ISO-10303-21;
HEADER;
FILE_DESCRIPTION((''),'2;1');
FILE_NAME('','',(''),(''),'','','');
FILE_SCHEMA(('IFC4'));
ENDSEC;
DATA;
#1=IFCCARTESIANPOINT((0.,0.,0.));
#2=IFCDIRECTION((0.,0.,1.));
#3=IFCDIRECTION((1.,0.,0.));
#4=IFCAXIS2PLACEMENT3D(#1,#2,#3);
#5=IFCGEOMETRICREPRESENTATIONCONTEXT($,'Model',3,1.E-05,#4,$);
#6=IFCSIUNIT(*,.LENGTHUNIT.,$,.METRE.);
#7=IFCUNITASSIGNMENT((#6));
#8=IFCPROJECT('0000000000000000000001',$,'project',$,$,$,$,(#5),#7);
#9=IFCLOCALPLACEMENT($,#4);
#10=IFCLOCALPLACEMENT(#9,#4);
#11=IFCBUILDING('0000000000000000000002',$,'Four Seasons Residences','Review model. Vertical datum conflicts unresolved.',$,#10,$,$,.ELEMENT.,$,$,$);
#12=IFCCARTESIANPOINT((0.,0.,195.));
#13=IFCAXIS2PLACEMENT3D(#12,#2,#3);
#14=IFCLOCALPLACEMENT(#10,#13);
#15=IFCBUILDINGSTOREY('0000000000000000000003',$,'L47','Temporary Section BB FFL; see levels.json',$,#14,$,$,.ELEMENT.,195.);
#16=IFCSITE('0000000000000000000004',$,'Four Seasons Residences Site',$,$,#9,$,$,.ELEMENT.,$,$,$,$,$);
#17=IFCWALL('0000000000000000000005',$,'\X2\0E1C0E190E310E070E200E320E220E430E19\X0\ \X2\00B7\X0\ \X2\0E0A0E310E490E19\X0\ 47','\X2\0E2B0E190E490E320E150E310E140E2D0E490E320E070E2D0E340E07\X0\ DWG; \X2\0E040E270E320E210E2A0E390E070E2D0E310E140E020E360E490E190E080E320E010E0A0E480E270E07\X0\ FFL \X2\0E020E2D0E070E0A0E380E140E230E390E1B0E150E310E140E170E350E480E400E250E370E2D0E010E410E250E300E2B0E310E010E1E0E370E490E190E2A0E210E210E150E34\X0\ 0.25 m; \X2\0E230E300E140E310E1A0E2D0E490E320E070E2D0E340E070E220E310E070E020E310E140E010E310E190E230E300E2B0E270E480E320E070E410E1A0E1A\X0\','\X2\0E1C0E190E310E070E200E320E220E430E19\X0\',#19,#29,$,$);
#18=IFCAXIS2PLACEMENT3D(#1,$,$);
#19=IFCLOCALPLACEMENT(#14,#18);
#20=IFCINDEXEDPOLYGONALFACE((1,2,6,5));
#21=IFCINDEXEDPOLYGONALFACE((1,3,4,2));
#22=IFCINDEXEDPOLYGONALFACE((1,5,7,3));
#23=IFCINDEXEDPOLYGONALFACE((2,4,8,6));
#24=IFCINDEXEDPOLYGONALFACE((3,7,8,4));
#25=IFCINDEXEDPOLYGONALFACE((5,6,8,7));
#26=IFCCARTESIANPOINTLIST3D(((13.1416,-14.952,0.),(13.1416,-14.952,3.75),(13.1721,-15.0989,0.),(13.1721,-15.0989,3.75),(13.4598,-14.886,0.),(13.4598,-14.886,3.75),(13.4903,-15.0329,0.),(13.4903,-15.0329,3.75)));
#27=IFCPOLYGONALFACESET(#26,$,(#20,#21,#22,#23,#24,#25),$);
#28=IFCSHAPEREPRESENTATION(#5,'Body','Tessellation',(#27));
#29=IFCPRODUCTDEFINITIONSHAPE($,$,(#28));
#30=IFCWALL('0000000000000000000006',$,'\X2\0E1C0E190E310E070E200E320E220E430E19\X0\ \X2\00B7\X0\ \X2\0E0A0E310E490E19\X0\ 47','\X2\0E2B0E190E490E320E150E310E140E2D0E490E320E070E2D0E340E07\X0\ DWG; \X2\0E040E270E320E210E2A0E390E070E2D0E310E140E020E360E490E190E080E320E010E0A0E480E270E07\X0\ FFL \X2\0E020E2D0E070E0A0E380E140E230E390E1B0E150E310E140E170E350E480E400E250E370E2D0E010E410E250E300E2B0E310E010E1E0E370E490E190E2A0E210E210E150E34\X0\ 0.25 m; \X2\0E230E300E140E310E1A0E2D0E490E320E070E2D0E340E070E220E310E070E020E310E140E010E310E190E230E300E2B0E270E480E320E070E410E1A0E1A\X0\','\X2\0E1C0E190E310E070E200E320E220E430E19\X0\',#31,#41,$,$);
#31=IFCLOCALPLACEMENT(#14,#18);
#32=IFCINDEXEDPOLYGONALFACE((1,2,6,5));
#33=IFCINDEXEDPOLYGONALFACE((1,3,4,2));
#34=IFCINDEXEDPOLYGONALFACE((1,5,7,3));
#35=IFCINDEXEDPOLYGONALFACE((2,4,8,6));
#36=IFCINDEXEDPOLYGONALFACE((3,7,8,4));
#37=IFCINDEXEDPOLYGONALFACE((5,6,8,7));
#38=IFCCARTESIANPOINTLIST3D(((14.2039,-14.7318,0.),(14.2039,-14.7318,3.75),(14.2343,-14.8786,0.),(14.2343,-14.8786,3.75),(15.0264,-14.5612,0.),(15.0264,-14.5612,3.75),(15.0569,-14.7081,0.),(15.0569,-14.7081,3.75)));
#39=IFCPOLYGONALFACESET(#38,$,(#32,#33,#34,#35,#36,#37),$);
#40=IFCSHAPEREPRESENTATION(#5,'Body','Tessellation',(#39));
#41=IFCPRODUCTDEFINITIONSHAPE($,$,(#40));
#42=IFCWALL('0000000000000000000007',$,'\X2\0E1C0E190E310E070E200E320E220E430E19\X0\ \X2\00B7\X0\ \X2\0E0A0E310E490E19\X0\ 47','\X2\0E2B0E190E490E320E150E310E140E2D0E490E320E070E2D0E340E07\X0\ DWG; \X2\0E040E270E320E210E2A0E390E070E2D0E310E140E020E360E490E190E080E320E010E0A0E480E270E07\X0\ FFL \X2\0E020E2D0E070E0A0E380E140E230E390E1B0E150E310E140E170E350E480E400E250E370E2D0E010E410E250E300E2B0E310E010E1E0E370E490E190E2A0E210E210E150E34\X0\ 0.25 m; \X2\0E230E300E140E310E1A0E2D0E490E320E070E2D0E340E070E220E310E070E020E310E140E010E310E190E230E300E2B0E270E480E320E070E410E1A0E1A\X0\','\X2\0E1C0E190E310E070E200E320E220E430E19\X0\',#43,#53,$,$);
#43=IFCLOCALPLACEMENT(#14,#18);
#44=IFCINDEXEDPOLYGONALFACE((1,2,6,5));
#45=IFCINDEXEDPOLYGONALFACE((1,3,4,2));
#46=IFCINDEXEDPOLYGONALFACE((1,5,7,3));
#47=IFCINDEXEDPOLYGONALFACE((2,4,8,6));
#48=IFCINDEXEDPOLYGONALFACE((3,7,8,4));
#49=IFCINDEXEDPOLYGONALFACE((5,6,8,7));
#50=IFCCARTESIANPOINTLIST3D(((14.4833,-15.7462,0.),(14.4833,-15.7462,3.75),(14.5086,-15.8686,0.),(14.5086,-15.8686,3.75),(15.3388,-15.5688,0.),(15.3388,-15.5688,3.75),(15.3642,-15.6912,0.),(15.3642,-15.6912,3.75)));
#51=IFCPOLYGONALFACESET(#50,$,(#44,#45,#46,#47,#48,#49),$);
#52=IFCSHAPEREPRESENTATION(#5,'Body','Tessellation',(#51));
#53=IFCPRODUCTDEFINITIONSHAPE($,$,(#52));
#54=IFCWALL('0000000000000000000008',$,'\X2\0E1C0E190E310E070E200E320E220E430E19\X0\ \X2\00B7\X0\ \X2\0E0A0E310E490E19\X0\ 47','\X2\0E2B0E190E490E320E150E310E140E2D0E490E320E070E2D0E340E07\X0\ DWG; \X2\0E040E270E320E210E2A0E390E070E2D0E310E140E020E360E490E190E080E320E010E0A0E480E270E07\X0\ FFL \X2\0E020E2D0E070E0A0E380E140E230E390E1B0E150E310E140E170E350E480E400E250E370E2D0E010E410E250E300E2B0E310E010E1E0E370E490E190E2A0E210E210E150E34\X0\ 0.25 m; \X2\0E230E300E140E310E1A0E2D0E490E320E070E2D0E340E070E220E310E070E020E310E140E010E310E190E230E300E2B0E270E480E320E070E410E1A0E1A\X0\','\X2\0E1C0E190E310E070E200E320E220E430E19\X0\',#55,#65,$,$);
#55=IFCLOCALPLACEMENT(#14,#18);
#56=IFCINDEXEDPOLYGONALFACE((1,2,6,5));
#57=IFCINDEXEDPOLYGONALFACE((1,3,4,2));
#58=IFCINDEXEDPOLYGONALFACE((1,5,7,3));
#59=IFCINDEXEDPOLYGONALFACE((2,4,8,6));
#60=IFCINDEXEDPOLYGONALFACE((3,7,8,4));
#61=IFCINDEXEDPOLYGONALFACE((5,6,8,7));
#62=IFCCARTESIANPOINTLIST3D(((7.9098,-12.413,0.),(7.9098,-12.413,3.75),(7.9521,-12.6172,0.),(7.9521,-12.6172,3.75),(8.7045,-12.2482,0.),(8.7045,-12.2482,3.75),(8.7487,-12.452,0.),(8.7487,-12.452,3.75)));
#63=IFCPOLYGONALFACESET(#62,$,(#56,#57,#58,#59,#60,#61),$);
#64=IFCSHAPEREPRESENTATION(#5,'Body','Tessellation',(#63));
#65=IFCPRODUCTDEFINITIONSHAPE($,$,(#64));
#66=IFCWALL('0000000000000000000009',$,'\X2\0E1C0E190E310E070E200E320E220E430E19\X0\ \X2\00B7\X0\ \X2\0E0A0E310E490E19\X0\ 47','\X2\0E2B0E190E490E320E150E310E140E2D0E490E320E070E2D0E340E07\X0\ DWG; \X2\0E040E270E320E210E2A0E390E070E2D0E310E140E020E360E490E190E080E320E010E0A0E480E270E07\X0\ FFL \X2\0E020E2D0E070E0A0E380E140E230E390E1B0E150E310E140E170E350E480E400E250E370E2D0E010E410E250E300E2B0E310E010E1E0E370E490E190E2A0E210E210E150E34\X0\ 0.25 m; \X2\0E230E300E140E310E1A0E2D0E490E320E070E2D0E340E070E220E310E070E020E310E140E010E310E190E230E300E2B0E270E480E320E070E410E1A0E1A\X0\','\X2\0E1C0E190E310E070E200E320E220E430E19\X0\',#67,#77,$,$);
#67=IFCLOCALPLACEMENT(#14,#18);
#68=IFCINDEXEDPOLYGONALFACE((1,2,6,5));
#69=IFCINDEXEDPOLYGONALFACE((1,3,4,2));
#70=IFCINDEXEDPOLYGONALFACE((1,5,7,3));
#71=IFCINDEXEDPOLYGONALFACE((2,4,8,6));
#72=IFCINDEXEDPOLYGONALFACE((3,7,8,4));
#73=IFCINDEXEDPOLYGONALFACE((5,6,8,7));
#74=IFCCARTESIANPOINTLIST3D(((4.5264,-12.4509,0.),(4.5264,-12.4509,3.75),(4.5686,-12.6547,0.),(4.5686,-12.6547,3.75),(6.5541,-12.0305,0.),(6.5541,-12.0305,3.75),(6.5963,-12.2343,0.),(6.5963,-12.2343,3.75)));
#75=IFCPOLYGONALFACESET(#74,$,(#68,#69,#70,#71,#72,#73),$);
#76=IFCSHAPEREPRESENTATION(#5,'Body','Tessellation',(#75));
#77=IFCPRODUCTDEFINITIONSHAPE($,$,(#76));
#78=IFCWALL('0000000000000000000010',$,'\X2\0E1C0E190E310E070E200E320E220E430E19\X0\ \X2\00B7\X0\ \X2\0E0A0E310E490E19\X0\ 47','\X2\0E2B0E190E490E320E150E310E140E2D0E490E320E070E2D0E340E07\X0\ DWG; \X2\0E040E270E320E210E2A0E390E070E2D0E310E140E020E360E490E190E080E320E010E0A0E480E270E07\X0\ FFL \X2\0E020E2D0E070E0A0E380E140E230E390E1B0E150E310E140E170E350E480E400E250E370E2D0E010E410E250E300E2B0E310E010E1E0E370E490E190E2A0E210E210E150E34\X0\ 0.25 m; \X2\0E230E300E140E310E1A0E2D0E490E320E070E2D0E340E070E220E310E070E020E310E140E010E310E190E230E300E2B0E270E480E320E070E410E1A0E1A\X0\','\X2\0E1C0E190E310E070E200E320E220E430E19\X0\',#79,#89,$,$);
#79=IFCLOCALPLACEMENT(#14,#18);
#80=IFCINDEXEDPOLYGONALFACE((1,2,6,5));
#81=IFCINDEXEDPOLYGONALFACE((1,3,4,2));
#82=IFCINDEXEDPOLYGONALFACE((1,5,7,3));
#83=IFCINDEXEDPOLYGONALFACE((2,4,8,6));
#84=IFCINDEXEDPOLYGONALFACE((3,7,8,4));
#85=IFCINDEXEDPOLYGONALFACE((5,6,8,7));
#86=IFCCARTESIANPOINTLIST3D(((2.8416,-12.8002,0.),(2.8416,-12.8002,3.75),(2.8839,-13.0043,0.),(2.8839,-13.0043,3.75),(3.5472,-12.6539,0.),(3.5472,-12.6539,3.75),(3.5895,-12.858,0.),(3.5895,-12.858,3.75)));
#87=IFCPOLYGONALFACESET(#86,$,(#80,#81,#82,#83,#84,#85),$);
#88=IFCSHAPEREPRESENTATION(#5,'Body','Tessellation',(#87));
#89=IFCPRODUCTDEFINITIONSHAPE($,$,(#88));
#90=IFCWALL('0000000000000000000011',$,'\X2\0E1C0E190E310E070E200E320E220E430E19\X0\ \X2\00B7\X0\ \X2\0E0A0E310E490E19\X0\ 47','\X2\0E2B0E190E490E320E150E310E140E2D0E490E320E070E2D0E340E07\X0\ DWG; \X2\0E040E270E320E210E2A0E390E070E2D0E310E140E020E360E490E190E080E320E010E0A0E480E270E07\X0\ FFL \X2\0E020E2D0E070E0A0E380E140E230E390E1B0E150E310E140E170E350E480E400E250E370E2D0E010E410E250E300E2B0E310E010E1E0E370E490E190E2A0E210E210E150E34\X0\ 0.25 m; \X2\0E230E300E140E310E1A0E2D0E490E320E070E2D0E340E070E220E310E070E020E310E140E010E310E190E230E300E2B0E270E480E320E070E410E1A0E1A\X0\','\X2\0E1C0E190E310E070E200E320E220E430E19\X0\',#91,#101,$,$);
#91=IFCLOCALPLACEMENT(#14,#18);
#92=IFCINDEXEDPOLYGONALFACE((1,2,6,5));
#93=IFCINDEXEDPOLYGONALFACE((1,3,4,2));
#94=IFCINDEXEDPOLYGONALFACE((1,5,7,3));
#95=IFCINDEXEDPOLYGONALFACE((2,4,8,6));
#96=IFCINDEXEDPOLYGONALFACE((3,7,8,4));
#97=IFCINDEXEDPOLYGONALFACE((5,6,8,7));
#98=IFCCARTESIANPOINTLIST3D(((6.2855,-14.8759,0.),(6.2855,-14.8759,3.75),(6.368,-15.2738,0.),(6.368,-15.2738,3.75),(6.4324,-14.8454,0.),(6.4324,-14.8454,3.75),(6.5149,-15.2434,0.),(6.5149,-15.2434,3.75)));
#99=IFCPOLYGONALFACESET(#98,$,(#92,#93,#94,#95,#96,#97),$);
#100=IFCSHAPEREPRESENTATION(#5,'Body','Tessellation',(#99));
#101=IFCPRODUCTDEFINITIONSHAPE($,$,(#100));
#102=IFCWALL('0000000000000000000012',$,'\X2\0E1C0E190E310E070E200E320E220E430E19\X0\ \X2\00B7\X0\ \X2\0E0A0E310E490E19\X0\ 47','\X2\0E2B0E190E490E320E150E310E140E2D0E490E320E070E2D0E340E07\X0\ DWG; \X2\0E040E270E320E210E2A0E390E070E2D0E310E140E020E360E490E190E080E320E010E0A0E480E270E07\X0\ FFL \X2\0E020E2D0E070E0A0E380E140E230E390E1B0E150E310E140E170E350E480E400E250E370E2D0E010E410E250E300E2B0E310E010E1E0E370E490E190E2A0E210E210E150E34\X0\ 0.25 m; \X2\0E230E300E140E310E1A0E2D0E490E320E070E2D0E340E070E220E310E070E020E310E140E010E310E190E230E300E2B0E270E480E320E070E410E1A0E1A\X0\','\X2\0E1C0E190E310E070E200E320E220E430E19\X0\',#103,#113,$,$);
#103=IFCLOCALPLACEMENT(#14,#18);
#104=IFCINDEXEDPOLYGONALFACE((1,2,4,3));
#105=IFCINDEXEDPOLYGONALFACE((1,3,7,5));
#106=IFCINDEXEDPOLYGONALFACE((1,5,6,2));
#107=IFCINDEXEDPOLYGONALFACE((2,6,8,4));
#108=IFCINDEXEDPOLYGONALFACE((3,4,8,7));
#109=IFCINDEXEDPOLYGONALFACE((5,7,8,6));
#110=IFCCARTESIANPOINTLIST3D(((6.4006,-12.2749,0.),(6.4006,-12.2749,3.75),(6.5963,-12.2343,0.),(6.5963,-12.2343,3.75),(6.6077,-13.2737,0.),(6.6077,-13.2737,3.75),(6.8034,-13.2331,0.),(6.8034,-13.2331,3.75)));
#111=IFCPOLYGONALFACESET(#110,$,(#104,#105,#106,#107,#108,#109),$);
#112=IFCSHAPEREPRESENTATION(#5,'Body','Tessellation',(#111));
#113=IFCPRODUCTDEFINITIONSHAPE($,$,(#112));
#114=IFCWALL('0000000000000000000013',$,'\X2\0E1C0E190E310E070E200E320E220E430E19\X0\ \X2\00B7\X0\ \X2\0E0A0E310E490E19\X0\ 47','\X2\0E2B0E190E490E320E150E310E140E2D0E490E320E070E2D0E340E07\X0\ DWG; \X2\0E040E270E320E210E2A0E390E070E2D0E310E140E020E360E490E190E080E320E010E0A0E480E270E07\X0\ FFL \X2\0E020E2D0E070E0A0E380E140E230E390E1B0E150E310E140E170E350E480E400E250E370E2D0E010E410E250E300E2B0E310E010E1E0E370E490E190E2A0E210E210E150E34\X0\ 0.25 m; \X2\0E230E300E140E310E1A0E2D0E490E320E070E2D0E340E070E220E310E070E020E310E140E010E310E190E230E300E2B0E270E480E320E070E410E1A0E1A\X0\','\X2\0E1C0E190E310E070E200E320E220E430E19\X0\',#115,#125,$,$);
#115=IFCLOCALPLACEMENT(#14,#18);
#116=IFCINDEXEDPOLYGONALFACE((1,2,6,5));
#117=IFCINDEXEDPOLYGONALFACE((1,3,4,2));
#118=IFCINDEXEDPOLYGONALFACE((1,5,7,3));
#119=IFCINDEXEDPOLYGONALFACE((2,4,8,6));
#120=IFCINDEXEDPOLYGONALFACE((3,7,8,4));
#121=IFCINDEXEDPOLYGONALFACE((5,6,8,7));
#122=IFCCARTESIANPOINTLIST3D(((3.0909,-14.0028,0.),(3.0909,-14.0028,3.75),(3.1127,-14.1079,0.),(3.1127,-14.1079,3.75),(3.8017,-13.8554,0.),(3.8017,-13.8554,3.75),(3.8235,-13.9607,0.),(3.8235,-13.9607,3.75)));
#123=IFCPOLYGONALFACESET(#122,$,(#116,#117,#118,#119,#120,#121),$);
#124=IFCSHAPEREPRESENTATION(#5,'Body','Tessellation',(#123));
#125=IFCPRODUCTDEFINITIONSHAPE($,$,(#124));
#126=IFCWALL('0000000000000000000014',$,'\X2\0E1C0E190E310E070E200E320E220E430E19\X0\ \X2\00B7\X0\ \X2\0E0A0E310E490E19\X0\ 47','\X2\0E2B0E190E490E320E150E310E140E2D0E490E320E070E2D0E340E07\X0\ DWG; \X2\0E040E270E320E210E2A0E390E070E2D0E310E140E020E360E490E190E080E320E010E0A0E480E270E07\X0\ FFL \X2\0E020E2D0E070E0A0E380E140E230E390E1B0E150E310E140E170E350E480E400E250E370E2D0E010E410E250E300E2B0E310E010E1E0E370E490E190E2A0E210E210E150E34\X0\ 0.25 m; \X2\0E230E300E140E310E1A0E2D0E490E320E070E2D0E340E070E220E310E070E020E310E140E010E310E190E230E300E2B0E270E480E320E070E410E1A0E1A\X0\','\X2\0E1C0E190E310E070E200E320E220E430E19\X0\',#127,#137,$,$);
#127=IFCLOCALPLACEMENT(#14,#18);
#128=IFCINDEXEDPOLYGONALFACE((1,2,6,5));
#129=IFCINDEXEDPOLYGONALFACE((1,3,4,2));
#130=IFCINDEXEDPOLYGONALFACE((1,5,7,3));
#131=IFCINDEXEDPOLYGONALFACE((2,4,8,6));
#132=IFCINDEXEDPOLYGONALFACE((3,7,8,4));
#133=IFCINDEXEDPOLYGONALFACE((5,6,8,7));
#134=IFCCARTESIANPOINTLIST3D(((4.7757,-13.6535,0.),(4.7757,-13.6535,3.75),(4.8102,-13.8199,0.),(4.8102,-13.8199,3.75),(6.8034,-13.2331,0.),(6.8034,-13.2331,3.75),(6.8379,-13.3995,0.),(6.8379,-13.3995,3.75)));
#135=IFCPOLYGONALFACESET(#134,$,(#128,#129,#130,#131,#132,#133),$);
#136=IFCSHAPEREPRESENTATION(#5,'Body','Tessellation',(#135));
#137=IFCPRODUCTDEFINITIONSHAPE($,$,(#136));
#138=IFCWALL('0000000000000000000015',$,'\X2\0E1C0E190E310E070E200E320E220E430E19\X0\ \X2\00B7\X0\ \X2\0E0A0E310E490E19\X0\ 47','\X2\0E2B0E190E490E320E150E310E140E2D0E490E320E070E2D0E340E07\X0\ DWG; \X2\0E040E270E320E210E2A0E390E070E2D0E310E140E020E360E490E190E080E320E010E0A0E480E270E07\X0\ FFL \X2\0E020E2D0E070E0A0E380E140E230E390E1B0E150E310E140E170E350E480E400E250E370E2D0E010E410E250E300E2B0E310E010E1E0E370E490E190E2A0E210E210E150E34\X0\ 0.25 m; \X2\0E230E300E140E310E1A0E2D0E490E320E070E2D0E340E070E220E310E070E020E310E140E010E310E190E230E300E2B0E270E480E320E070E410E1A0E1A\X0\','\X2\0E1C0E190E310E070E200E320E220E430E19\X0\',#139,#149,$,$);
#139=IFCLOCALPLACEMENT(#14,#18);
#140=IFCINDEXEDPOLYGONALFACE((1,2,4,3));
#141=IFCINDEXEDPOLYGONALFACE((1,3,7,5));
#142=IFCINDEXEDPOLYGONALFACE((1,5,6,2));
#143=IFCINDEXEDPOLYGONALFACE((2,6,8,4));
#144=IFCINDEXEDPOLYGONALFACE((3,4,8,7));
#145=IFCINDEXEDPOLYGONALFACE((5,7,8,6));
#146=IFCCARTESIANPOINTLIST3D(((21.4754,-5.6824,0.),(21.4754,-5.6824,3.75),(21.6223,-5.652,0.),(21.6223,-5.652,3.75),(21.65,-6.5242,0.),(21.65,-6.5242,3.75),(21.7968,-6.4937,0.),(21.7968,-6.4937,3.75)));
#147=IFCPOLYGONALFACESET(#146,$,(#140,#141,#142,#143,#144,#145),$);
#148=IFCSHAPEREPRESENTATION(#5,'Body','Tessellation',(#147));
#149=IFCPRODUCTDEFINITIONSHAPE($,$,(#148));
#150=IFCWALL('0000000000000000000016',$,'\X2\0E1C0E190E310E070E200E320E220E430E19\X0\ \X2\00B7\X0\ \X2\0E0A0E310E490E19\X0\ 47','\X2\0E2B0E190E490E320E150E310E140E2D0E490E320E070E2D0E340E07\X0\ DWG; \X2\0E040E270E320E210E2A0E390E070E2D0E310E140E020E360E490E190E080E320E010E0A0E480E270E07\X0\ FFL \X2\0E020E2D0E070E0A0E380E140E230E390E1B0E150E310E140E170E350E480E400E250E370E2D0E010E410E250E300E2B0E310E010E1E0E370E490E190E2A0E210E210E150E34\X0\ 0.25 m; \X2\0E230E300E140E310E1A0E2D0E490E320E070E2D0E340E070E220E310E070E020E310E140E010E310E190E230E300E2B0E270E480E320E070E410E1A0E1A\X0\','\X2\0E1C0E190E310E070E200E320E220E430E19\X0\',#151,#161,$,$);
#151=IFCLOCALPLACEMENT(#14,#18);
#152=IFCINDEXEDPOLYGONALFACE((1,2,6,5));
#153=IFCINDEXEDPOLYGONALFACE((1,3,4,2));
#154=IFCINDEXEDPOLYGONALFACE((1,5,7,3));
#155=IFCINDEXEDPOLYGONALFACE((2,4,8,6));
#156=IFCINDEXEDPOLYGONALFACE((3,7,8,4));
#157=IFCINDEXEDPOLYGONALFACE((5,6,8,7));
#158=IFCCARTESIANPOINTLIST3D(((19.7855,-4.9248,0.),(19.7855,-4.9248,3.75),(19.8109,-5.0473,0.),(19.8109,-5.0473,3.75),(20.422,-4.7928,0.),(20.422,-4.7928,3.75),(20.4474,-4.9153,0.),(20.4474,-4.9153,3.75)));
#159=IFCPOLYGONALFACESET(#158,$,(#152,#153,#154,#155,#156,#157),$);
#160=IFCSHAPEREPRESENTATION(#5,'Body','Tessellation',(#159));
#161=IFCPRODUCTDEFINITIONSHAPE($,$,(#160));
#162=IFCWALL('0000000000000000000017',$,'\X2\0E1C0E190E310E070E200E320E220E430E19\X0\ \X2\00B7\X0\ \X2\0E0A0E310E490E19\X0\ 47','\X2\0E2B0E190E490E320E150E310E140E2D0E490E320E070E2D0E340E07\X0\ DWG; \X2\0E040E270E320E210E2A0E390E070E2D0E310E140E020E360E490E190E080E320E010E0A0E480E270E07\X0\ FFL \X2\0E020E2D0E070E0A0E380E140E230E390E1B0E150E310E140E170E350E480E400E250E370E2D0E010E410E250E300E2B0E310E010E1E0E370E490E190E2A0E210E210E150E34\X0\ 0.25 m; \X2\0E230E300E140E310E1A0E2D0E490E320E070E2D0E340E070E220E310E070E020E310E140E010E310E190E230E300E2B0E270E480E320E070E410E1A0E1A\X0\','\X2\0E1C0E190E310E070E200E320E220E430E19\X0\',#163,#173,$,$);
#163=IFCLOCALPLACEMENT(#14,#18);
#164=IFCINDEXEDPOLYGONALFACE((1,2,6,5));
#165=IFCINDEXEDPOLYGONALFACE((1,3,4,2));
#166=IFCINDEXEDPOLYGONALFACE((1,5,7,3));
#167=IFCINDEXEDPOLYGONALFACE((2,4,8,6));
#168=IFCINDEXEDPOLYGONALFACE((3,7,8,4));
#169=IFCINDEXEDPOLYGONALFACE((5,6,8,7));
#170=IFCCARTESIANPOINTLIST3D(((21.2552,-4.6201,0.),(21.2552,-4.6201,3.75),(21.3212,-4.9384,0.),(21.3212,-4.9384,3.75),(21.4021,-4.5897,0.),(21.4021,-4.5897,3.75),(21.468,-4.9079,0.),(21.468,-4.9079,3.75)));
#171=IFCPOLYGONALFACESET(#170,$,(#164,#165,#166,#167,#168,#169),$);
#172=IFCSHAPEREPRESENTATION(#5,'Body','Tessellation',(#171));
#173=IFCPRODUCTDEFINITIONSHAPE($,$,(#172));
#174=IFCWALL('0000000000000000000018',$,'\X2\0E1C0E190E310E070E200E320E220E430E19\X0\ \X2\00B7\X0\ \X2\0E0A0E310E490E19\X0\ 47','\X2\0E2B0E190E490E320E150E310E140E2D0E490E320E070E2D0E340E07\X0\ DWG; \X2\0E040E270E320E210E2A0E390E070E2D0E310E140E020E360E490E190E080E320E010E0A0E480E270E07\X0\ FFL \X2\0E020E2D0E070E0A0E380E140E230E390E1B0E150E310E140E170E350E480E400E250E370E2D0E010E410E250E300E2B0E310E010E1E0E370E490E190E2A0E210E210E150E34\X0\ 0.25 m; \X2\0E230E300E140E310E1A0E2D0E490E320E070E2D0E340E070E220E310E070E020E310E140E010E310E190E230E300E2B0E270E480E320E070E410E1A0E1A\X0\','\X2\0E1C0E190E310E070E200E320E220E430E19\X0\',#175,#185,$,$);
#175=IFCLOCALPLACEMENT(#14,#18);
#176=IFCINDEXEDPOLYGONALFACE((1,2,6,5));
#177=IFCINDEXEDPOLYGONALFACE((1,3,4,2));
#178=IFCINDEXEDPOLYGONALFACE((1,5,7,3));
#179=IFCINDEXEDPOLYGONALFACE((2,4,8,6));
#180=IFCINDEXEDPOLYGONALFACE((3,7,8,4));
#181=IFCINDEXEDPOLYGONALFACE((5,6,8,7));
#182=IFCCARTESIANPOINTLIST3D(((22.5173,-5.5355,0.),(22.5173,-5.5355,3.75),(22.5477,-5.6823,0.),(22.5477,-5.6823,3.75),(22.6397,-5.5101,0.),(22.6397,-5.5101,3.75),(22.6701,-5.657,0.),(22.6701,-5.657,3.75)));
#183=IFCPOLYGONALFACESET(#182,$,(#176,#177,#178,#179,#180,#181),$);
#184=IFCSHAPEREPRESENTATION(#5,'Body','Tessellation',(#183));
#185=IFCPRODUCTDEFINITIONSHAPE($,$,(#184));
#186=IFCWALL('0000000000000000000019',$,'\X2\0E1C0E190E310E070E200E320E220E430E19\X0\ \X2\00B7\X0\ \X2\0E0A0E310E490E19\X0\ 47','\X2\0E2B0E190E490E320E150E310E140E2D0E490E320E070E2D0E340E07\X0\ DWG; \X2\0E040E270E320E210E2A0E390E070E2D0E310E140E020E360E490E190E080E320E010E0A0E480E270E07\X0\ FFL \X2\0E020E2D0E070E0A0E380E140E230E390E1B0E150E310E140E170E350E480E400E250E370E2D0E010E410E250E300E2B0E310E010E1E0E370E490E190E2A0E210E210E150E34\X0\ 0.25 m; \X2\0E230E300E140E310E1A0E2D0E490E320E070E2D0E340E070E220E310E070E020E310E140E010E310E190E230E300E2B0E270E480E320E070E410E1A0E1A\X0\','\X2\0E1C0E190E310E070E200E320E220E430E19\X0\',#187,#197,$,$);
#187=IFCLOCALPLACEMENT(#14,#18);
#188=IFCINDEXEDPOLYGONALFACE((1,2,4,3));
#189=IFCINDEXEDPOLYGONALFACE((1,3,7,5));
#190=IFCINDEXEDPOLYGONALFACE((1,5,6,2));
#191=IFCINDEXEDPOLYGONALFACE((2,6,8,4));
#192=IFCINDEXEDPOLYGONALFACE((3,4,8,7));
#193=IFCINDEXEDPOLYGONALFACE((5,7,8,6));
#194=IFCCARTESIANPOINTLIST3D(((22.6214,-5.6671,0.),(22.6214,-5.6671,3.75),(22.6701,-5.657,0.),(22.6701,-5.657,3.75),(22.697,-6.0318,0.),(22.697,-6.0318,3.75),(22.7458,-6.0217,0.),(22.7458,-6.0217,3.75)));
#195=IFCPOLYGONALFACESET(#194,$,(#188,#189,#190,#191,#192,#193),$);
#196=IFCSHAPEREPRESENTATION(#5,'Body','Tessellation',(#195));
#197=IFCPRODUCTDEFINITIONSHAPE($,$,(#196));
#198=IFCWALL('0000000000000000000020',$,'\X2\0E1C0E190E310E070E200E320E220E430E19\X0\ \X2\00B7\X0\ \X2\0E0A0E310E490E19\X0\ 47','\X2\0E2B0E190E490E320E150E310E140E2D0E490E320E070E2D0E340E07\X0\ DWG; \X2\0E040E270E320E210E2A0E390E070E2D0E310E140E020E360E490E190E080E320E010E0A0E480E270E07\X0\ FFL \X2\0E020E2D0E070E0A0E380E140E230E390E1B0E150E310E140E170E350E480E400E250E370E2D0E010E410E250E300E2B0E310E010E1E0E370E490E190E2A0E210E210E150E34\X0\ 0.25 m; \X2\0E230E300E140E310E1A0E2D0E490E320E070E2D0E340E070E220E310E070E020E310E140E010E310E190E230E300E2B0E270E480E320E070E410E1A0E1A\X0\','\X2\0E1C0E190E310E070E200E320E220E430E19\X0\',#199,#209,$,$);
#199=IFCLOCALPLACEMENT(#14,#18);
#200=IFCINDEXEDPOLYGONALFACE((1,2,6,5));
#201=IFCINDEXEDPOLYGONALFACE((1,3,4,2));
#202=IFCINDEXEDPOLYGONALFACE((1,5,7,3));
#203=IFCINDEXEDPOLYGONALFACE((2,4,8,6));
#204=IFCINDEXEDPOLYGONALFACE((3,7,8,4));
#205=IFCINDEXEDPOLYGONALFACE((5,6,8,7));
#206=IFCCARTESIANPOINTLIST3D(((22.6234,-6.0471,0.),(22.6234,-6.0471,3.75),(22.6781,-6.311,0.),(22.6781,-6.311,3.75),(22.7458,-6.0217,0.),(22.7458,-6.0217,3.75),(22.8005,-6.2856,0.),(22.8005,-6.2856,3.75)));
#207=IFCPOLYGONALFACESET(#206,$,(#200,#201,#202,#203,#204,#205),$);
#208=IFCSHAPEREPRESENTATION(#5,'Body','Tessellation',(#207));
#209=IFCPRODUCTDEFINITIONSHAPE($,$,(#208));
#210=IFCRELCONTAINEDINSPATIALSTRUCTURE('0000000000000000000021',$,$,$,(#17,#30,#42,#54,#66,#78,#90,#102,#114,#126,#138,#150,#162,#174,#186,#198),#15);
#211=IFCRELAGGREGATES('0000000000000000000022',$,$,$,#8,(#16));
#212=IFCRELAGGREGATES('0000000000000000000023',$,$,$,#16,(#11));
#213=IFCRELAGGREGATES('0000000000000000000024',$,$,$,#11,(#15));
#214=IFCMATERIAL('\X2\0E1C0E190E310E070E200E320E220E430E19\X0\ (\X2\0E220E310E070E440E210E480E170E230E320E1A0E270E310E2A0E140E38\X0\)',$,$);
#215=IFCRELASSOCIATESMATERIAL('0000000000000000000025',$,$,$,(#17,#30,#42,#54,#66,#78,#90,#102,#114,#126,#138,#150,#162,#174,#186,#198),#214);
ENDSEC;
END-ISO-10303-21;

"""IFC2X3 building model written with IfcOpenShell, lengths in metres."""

from ifc_helpers import new_model, si_unit, frame, origin_with_axes, place, context, project, spatial, polyline, outline, extrude, material, element, save


model = new_model("IFC2X3")

# Units and contexts
model_context = context("Model", 3, precision=1e-05, world=origin_with_axes())
ifc_project = project(units=[si_unit("LENGTHUNIT", "METRE")], contexts=[model_context])

# Site, building, storey
site_placement = place(None, origin_with_axes())
site = spatial("IfcSite", under=ifc_project, at=site_placement, Name="Four Seasons Residences Site", CompositionType="ELEMENT")
building_placement = place(site_placement, origin_with_axes())
building = spatial("IfcBuilding", under=site, at=building_placement, Name="Four Seasons Residences", Description="Review model. Vertical datum conflicts unresolved.", CompositionType="ELEMENT")
storey_placement = place(building_placement, frame((0.0, 0.0, 195.0), z_axis=(0.0, 0.0, 1.0), x_axis=(1.0, 0.0, 0.0)))
storey = spatial("IfcBuildingStorey", under=building, at=storey_placement, Name="L47", Description="Temporary Section BB FFL; see levels.json", CompositionType="ELEMENT", Elevation=195.0)

# Walls
ifc_material = material(Name="ผนังภายใน (ยังไม่ทราบวัสดุ)")
wall_1_placement = place(storey_placement, origin_with_axes())
element("IfcWall", 1, at=wall_1_placement, inside=storey, material=ifc_material, Name="ผนังภายใน · ชั้น 47", Description="หน้าตัดอ้างอิง DWG; ความสูงอัดขึ้นจากช่วง FFL ของชุดรูปตัดที่เลือกและหักพื้นสมมติ 0.25 m; ระดับอ้างอิงยังขัดกันระหว่างแบบ", ObjectType="ผนังภายใน", context=model_context, shape_type="SweptSolid", body=[
    extrude(outline(polyline([(13.4598, -14.886), (13.1416, -14.952), (13.1721, -15.0989), (13.4903, -15.0329), (13.4598, -14.886)])), origin_with_axes(), (0.0, 0.0, 1.0), 3.75),
])
wall_2_placement = place(storey_placement, origin_with_axes())
element("IfcWall", 2, at=wall_2_placement, inside=storey, material=ifc_material, Name="ผนังภายใน · ชั้น 47", Description="หน้าตัดอ้างอิง DWG; ความสูงอัดขึ้นจากช่วง FFL ของชุดรูปตัดที่เลือกและหักพื้นสมมติ 0.25 m; ระดับอ้างอิงยังขัดกันระหว่างแบบ", ObjectType="ผนังภายใน", context=model_context, shape_type="SweptSolid", body=[
    extrude(outline(polyline([(15.0264, -14.5612), (14.2039, -14.7318), (14.2343, -14.8786), (15.0569, -14.7081), (15.0264, -14.5612)])), origin_with_axes(), (0.0, 0.0, 1.0), 3.75),
])
wall_3_placement = place(storey_placement, origin_with_axes())
element("IfcWall", 3, at=wall_3_placement, inside=storey, material=ifc_material, Name="ผนังภายใน · ชั้น 47", Description="หน้าตัดอ้างอิง DWG; ความสูงอัดขึ้นจากช่วง FFL ของชุดรูปตัดที่เลือกและหักพื้นสมมติ 0.25 m; ระดับอ้างอิงยังขัดกันระหว่างแบบ", ObjectType="ผนังภายใน", context=model_context, shape_type="SweptSolid", body=[
    extrude(outline(polyline([(15.3388, -15.5688), (14.4833, -15.7462), (14.5086, -15.8686), (15.3642, -15.6912), (15.3388, -15.5688)])), origin_with_axes(), (0.0, 0.0, 1.0), 3.75),
])
wall_4_placement = place(storey_placement, origin_with_axes())
element("IfcWall", 4, at=wall_4_placement, inside=storey, material=ifc_material, Name="ผนังภายใน · ชั้น 47", Description="หน้าตัดอ้างอิง DWG; ความสูงอัดขึ้นจากช่วง FFL ของชุดรูปตัดที่เลือกและหักพื้นสมมติ 0.25 m; ระดับอ้างอิงยังขัดกันระหว่างแบบ", ObjectType="ผนังภายใน", context=model_context, shape_type="SweptSolid", body=[
    extrude(outline(polyline([(8.7045, -12.2482), (7.9098, -12.413), (7.9521, -12.6172), (8.7487, -12.452), (8.7045, -12.2482)])), origin_with_axes(), (0.0, 0.0, 1.0), 3.75),
])
wall_5_placement = place(storey_placement, origin_with_axes())
element("IfcWall", 5, at=wall_5_placement, inside=storey, material=ifc_material, Name="ผนังภายใน · ชั้น 47", Description="หน้าตัดอ้างอิง DWG; ความสูงอัดขึ้นจากช่วง FFL ของชุดรูปตัดที่เลือกและหักพื้นสมมติ 0.25 m; ระดับอ้างอิงยังขัดกันระหว่างแบบ", ObjectType="ผนังภายใน", context=model_context, shape_type="SweptSolid", body=[
    extrude(outline(polyline([(6.5541, -12.0305), (4.5264, -12.4509), (4.5686, -12.6547), (6.5963, -12.2343), (6.5541, -12.0305)])), origin_with_axes(), (0.0, 0.0, 1.0), 3.75),
])
wall_6_placement = place(storey_placement, origin_with_axes())
element("IfcWall", 6, at=wall_6_placement, inside=storey, material=ifc_material, Name="ผนังภายใน · ชั้น 47", Description="หน้าตัดอ้างอิง DWG; ความสูงอัดขึ้นจากช่วง FFL ของชุดรูปตัดที่เลือกและหักพื้นสมมติ 0.25 m; ระดับอ้างอิงยังขัดกันระหว่างแบบ", ObjectType="ผนังภายใน", context=model_context, shape_type="SweptSolid", body=[
    extrude(outline(polyline([(3.5895, -12.858), (2.8839, -13.0043), (2.8416, -12.8002), (3.5472, -12.6539), (3.5895, -12.858)])), origin_with_axes(), (0.0, 0.0, 1.0), 3.75),
])
wall_7_placement = place(storey_placement, origin_with_axes())
element("IfcWall", 7, at=wall_7_placement, inside=storey, material=ifc_material, Name="ผนังภายใน · ชั้น 47", Description="หน้าตัดอ้างอิง DWG; ความสูงอัดขึ้นจากช่วง FFL ของชุดรูปตัดที่เลือกและหักพื้นสมมติ 0.25 m; ระดับอ้างอิงยังขัดกันระหว่างแบบ", ObjectType="ผนังภายใน", context=model_context, shape_type="SweptSolid", body=[
    extrude(outline(polyline([(6.2855, -14.8759), (6.4324, -14.8454), (6.5149, -15.2434), (6.368, -15.2738), (6.2855, -14.8759)])), origin_with_axes(), (0.0, 0.0, 1.0), 3.75),
])
wall_8_placement = place(storey_placement, origin_with_axes())
element("IfcWall", 8, at=wall_8_placement, inside=storey, material=ifc_material, Name="ผนังภายใน · ชั้น 47", Description="หน้าตัดอ้างอิง DWG; ความสูงอัดขึ้นจากช่วง FFL ของชุดรูปตัดที่เลือกและหักพื้นสมมติ 0.25 m; ระดับอ้างอิงยังขัดกันระหว่างแบบ", ObjectType="ผนังภายใน", context=model_context, shape_type="SweptSolid", body=[
    extrude(outline(polyline([(6.5963, -12.2343), (6.4006, -12.2749), (6.6077, -13.2737), (6.8034, -13.2331), (6.5963, -12.2343)])), origin_with_axes(), (0.0, 0.0, 1.0), 3.75),
])
wall_9_placement = place(storey_placement, origin_with_axes())
element("IfcWall", 9, at=wall_9_placement, inside=storey, material=ifc_material, Name="ผนังภายใน · ชั้น 47", Description="หน้าตัดอ้างอิง DWG; ความสูงอัดขึ้นจากช่วง FFL ของชุดรูปตัดที่เลือกและหักพื้นสมมติ 0.25 m; ระดับอ้างอิงยังขัดกันระหว่างแบบ", ObjectType="ผนังภายใน", context=model_context, shape_type="SweptSolid", body=[
    extrude(outline(polyline([(3.8017, -13.8554), (3.0909, -14.0028), (3.1127, -14.1079), (3.8235, -13.9607), (3.8017, -13.8554)])), origin_with_axes(), (0.0, 0.0, 1.0), 3.75),
])
wall_10_placement = place(storey_placement, origin_with_axes())
element("IfcWall", 10, at=wall_10_placement, inside=storey, material=ifc_material, Name="ผนังภายใน · ชั้น 47", Description="หน้าตัดอ้างอิง DWG; ความสูงอัดขึ้นจากช่วง FFL ของชุดรูปตัดที่เลือกและหักพื้นสมมติ 0.25 m; ระดับอ้างอิงยังขัดกันระหว่างแบบ", ObjectType="ผนังภายใน", context=model_context, shape_type="SweptSolid", body=[
    extrude(outline(polyline([(6.8034, -13.2331), (4.7757, -13.6535), (4.8102, -13.8199), (6.8379, -13.3995), (6.8034, -13.2331)])), origin_with_axes(), (0.0, 0.0, 1.0), 3.75),
])
wall_11_placement = place(storey_placement, origin_with_axes())
element("IfcWall", 11, at=wall_11_placement, inside=storey, material=ifc_material, Name="ผนังภายใน · ชั้น 47", Description="หน้าตัดอ้างอิง DWG; ความสูงอัดขึ้นจากช่วง FFL ของชุดรูปตัดที่เลือกและหักพื้นสมมติ 0.25 m; ระดับอ้างอิงยังขัดกันระหว่างแบบ", ObjectType="ผนังภายใน", context=model_context, shape_type="SweptSolid", body=[
    extrude(outline(polyline([(21.4754, -5.6824), (21.6223, -5.652), (21.7968, -6.4937), (21.65, -6.5242), (21.4754, -5.6824)])), origin_with_axes(), (0.0, 0.0, 1.0), 3.75),
])
wall_12_placement = place(storey_placement, origin_with_axes())
element("IfcWall", 12, at=wall_12_placement, inside=storey, material=ifc_material, Name="ผนังภายใน · ชั้น 47", Description="หน้าตัดอ้างอิง DWG; ความสูงอัดขึ้นจากช่วง FFL ของชุดรูปตัดที่เลือกและหักพื้นสมมติ 0.25 m; ระดับอ้างอิงยังขัดกันระหว่างแบบ", ObjectType="ผนังภายใน", context=model_context, shape_type="SweptSolid", body=[
    extrude(outline(polyline([(20.422, -4.7928), (19.7855, -4.9248), (19.8109, -5.0473), (20.4474, -4.9153), (20.422, -4.7928)])), origin_with_axes(), (0.0, 0.0, 1.0), 3.75),
])
wall_13_placement = place(storey_placement, origin_with_axes())
element("IfcWall", 13, at=wall_13_placement, inside=storey, material=ifc_material, Name="ผนังภายใน · ชั้น 47", Description="หน้าตัดอ้างอิง DWG; ความสูงอัดขึ้นจากช่วง FFL ของชุดรูปตัดที่เลือกและหักพื้นสมมติ 0.25 m; ระดับอ้างอิงยังขัดกันระหว่างแบบ", ObjectType="ผนังภายใน", context=model_context, shape_type="SweptSolid", body=[
    extrude(outline(polyline([(21.4021, -4.5897), (21.2552, -4.6201), (21.3212, -4.9384), (21.468, -4.9079), (21.4021, -4.5897)])), origin_with_axes(), (0.0, 0.0, 1.0), 3.75),
])
wall_14_placement = place(storey_placement, origin_with_axes())
element("IfcWall", 14, at=wall_14_placement, inside=storey, material=ifc_material, Name="ผนังภายใน · ชั้น 47", Description="หน้าตัดอ้างอิง DWG; ความสูงอัดขึ้นจากช่วง FFL ของชุดรูปตัดที่เลือกและหักพื้นสมมติ 0.25 m; ระดับอ้างอิงยังขัดกันระหว่างแบบ", ObjectType="ผนังภายใน", context=model_context, shape_type="SweptSolid", body=[
    extrude(outline(polyline([(22.6397, -5.5101), (22.5173, -5.5355), (22.5477, -5.6823), (22.6701, -5.657), (22.6397, -5.5101)])), origin_with_axes(), (0.0, 0.0, 1.0), 3.75),
])
wall_15_placement = place(storey_placement, origin_with_axes())
element("IfcWall", 15, at=wall_15_placement, inside=storey, material=ifc_material, Name="ผนังภายใน · ชั้น 47", Description="หน้าตัดอ้างอิง DWG; ความสูงอัดขึ้นจากช่วง FFL ของชุดรูปตัดที่เลือกและหักพื้นสมมติ 0.25 m; ระดับอ้างอิงยังขัดกันระหว่างแบบ", ObjectType="ผนังภายใน", context=model_context, shape_type="SweptSolid", body=[
    extrude(outline(polyline([(22.697, -6.0318), (22.7458, -6.0217), (22.6701, -5.657), (22.6214, -5.6671), (22.697, -6.0318)])), origin_with_axes(), (0.0, 0.0, 1.0), 3.75),
])
wall_16_placement = place(storey_placement, origin_with_axes())
element("IfcWall", 16, at=wall_16_placement, inside=storey, material=ifc_material, Name="ผนังภายใน · ชั้น 47", Description="หน้าตัดอ้างอิง DWG; ความสูงอัดขึ้นจากช่วง FFL ของชุดรูปตัดที่เลือกและหักพื้นสมมติ 0.25 m; ระดับอ้างอิงยังขัดกันระหว่างแบบ", ObjectType="ผนังภายใน", context=model_context, shape_type="SweptSolid", body=[
    extrude(outline(polyline([(22.6234, -6.0471), (22.7458, -6.0217), (22.8005, -6.2856), (22.6781, -6.311), (22.6234, -6.0471)])), origin_with_axes(), (0.0, 0.0, 1.0), 3.75),
])

save(model, "model.ifc")
